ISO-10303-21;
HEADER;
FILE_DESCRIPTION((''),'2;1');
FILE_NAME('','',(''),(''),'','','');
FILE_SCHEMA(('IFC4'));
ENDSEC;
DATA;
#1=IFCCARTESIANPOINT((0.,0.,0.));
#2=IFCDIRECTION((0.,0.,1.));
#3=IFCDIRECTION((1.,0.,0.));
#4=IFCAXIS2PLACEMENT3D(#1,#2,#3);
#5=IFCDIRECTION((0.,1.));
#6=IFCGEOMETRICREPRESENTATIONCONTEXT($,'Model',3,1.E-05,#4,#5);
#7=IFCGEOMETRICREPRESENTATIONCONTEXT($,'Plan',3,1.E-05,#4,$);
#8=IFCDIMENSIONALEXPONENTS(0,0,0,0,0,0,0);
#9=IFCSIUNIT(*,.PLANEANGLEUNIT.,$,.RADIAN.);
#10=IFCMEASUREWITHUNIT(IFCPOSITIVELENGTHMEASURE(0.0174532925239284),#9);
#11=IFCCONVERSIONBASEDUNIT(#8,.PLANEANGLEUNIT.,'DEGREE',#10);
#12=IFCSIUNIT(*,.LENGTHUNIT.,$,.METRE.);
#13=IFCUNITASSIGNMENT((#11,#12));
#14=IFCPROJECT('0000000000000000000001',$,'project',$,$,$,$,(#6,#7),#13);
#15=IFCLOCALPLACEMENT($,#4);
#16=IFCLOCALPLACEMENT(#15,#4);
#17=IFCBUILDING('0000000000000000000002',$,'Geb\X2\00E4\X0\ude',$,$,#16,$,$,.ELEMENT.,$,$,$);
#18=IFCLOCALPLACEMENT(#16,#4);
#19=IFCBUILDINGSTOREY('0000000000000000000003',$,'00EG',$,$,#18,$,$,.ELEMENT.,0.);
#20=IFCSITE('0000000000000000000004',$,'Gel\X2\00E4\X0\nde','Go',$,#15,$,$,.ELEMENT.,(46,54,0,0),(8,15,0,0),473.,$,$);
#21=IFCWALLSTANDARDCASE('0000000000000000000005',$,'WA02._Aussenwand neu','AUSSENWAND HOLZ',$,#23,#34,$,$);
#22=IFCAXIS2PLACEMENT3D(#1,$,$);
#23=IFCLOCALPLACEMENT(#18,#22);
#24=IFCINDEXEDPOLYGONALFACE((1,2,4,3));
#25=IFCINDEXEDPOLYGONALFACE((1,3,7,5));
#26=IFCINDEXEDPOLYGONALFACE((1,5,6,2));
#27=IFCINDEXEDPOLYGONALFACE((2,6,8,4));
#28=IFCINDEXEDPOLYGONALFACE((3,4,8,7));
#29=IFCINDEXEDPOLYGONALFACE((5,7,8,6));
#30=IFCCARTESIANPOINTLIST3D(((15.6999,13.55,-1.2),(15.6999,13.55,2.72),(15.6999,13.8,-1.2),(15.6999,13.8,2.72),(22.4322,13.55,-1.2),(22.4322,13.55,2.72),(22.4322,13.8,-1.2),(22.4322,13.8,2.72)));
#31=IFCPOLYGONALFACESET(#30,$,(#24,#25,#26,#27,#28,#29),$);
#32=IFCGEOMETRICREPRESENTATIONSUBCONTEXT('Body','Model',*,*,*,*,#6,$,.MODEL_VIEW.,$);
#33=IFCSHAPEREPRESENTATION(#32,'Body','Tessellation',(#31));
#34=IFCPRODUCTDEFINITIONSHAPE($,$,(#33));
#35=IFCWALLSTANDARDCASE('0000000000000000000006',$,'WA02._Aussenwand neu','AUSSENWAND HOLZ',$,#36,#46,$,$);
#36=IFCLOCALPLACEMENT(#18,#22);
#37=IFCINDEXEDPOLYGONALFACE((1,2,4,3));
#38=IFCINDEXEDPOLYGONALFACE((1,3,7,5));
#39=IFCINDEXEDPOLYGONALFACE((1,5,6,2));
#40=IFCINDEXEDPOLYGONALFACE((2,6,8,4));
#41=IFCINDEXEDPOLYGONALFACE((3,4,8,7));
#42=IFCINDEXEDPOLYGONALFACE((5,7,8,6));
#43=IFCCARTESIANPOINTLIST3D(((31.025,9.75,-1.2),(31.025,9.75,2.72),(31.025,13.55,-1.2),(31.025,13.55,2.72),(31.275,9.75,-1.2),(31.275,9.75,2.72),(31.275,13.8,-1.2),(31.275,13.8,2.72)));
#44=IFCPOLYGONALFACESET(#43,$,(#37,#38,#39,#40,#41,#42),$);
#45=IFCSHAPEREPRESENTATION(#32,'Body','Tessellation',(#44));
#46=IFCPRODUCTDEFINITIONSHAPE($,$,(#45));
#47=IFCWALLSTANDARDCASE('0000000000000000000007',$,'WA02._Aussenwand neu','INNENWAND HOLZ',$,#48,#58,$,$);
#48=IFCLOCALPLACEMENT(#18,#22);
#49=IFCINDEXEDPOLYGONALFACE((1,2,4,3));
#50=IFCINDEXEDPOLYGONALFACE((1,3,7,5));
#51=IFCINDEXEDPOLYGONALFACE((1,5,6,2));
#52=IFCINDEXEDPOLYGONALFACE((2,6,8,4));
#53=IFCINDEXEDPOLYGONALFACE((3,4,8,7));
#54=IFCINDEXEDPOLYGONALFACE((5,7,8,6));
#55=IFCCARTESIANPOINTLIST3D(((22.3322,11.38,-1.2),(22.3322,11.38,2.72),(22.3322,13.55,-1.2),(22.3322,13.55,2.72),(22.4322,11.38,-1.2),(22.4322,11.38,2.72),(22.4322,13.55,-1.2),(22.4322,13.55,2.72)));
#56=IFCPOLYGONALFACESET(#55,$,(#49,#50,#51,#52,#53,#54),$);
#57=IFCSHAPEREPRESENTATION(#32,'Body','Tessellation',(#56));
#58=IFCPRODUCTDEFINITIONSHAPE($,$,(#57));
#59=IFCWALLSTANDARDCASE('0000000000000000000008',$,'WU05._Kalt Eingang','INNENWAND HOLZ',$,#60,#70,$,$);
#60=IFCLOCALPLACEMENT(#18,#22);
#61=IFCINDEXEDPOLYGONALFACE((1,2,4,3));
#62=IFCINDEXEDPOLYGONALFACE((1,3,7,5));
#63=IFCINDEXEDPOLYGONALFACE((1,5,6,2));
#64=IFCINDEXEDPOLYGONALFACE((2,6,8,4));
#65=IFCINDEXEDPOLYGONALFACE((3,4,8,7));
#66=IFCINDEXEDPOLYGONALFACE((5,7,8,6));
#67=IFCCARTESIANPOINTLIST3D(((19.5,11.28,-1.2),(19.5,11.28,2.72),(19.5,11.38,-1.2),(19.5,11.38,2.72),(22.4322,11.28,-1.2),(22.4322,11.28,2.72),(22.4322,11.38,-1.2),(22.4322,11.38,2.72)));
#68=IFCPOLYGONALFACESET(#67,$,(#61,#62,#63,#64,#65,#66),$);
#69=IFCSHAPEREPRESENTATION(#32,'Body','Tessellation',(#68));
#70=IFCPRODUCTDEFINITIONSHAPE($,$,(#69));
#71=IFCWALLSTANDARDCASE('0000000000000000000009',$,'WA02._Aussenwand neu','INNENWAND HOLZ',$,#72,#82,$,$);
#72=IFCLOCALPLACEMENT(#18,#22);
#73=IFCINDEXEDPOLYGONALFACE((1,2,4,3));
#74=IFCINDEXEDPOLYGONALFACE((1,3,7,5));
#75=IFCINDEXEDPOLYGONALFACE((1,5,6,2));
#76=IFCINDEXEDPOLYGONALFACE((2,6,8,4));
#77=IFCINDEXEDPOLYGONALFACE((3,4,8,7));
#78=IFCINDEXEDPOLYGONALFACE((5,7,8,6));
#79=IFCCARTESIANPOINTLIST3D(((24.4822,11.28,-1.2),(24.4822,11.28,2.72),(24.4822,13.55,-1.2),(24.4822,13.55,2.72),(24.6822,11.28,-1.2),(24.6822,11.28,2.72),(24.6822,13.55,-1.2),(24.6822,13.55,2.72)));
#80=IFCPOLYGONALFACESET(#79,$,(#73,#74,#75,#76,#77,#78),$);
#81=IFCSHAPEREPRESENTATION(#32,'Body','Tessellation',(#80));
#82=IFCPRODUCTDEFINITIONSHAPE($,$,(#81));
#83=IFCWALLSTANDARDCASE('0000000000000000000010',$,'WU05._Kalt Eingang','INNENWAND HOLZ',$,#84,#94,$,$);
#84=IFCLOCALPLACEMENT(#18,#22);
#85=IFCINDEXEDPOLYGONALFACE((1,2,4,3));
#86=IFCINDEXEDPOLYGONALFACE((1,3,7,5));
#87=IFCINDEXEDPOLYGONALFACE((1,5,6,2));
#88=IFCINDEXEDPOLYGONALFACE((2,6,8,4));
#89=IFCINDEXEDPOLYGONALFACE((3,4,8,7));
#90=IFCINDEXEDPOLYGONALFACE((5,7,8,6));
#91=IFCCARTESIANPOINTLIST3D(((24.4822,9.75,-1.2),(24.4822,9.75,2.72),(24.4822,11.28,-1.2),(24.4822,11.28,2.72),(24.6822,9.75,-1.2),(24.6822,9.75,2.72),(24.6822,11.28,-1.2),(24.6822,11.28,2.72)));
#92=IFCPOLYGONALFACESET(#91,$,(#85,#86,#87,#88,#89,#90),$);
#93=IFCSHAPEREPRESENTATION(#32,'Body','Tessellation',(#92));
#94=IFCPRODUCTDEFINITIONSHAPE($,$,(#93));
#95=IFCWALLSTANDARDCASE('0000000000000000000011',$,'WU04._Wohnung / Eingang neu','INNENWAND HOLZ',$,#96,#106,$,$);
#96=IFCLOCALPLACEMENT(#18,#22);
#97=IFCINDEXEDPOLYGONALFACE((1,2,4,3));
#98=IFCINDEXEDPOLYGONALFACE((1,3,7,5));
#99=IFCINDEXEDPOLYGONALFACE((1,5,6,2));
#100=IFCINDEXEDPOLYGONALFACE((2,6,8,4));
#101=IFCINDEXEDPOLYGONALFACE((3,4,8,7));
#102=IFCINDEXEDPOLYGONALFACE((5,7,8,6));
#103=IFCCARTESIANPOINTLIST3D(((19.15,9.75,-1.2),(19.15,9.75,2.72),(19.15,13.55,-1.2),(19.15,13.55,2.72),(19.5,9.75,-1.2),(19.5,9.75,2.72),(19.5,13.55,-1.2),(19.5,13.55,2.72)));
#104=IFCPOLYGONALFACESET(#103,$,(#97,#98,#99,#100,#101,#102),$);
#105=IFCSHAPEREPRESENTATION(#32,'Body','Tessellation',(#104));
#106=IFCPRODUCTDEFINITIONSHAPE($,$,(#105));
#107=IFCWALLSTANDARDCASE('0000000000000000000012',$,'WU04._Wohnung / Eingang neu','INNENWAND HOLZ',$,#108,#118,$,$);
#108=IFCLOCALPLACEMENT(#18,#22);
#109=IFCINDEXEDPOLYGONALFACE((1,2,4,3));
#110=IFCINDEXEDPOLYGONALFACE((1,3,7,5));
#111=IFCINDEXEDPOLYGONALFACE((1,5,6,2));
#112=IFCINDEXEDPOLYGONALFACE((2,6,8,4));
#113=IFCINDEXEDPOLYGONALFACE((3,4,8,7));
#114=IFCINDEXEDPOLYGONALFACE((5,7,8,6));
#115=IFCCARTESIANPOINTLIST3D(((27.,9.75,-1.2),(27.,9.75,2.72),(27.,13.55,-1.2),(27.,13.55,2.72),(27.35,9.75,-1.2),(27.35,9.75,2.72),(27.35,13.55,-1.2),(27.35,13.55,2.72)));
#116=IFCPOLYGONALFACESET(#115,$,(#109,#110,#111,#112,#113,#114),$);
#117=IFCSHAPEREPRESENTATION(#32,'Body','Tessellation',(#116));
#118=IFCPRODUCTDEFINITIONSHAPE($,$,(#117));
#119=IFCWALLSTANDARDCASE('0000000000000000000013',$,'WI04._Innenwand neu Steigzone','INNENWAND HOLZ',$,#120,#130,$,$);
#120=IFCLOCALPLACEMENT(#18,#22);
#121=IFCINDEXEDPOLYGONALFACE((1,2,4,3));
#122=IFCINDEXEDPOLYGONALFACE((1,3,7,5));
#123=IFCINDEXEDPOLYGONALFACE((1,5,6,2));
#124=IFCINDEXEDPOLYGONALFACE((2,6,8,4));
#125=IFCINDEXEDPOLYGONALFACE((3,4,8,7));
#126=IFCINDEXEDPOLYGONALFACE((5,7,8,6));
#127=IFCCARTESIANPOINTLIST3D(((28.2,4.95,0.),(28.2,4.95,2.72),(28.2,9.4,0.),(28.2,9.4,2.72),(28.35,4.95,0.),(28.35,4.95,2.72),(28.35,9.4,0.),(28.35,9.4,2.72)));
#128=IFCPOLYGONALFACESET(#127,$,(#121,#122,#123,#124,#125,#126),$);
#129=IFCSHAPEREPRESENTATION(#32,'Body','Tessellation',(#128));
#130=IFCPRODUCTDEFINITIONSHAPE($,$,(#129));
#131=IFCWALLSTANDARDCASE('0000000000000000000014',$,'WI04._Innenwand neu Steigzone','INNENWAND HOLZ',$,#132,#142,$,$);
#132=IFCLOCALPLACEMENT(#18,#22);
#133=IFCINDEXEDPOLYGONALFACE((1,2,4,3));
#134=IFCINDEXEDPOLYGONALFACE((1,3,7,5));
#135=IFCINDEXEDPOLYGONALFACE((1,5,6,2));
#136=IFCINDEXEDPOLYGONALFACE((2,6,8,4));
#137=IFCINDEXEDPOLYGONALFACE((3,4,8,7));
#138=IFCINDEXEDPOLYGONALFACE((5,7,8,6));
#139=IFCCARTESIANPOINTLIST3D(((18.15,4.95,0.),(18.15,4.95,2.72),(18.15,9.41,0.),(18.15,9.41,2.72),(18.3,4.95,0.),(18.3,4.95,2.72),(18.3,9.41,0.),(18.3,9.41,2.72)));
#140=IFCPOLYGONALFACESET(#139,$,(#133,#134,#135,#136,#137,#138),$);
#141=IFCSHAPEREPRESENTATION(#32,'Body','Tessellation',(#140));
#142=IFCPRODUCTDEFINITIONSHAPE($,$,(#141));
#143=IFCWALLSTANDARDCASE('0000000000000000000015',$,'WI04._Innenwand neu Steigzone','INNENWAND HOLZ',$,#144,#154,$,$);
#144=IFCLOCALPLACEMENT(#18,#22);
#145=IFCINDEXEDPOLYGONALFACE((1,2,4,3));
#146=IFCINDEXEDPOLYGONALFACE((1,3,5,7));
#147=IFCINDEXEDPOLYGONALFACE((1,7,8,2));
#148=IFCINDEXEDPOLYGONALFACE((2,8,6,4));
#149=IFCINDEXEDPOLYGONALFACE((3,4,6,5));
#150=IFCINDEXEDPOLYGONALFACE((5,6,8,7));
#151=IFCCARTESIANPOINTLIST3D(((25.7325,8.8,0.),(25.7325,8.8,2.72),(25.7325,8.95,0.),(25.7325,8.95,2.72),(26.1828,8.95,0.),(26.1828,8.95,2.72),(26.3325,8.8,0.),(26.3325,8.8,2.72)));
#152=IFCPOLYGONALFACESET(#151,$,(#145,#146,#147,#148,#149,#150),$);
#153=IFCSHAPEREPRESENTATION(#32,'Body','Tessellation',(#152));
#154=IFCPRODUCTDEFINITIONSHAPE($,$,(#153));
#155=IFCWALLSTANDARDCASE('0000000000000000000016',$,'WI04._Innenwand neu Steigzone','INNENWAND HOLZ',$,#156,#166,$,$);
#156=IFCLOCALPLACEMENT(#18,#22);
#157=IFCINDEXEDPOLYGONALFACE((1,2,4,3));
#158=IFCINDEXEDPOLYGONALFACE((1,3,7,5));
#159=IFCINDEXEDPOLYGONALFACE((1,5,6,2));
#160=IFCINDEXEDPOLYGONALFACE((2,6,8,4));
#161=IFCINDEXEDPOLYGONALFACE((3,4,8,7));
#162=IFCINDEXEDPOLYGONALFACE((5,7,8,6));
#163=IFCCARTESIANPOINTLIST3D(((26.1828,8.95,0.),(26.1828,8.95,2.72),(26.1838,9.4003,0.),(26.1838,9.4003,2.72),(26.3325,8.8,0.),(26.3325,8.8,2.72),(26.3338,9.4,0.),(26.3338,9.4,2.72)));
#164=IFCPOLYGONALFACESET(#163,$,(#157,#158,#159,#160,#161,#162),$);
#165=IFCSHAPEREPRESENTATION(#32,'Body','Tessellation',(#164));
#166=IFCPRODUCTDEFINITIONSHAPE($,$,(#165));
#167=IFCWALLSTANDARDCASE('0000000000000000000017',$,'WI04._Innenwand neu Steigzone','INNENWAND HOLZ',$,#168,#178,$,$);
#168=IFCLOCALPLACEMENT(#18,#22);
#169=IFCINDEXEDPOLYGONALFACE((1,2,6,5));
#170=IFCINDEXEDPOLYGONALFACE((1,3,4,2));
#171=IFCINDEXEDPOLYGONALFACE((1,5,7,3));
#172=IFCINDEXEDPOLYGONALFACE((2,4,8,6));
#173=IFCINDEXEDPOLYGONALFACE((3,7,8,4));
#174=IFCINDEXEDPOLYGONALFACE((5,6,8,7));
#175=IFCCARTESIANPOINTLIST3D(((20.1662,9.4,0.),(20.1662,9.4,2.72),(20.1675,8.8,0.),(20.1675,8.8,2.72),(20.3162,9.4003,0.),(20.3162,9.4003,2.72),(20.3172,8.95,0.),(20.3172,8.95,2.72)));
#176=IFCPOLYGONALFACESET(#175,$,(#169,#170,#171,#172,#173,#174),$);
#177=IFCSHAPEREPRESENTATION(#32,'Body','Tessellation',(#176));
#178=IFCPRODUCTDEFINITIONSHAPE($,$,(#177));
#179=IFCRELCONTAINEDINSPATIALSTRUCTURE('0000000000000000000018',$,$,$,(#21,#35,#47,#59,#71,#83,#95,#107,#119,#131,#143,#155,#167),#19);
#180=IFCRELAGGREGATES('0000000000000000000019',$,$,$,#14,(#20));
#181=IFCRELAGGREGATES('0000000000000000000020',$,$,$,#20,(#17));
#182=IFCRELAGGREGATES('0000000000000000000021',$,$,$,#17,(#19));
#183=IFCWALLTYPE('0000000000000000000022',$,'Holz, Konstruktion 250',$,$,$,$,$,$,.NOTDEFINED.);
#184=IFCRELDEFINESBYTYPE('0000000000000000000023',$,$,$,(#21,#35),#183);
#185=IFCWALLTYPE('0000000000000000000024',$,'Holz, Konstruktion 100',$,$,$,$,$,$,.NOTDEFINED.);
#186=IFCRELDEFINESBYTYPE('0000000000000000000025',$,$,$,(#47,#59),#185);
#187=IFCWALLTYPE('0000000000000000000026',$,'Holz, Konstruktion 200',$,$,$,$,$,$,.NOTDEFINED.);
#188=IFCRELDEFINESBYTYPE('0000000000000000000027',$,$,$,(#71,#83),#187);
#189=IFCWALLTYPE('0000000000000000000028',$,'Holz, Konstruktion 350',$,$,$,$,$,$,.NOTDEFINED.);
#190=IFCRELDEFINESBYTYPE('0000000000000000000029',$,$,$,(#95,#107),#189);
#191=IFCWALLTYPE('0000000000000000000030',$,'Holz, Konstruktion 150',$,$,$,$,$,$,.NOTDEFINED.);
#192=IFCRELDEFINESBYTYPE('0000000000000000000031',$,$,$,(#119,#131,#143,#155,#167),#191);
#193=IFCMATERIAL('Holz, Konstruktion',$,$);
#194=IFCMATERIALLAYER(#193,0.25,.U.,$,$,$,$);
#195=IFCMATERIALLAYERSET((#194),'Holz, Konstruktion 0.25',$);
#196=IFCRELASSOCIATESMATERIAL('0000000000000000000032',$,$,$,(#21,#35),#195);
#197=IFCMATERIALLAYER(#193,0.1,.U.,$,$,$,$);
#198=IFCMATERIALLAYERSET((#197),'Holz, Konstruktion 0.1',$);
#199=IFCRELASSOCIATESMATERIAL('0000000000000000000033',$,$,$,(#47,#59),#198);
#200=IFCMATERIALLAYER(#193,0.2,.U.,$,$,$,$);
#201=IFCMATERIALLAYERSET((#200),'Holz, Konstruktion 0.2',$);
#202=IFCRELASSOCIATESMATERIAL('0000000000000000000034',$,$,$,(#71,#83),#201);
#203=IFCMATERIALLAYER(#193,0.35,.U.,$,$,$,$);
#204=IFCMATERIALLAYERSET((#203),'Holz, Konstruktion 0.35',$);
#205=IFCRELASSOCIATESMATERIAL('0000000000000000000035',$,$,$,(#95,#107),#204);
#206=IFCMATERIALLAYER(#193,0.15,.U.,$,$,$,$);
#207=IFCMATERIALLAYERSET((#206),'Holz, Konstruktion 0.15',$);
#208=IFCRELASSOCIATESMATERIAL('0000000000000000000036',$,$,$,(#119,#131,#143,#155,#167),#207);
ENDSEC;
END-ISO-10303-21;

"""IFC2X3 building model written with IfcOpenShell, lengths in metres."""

from ifc_helpers import new_model, entity, si_unit, converted_unit, direction, frame, origin_with_axes, place, context, subcontext, project, spatial, polyline, outline, extrude, material, layer, layer_set, layer_usage, type_object, element, save


model = new_model("IFC2X3")

# Units and contexts
model_context = context("Model", 3, precision=1e-05, world=origin_with_axes(), true_north=direction((0.0, 1.0)))
plan_context = context("Plan", 3, precision=1e-05, world=origin_with_axes())
body_context = subcontext(model_context, "Body", "Model", "MODEL_VIEW")
ifc_project = project(units=[converted_unit("PLANEANGLEUNIT", "DEGREE", entity("IfcPositiveLengthMeasure", 0.0174532925239284), si_unit("PLANEANGLEUNIT", "RADIAN"), dimensions=[0, 0, 0, 0, 0, 0, 0]), si_unit("LENGTHUNIT", "METRE")], contexts=[model_context, plan_context])

# Site, building, storey
site_placement = place(None, origin_with_axes())
site = spatial("IfcSite", under=ifc_project, at=site_placement, Name="Gelände", Description="Go", CompositionType="ELEMENT", RefLatitude=(46, 54, 0, 0), RefLongitude=(8, 15, 0, 0), RefElevation=473.0)
building_placement = place(site_placement, origin_with_axes())
building = spatial("IfcBuilding", under=site, at=building_placement, Name="Gebäude", CompositionType="ELEMENT")
storey_placement = place(building_placement, origin_with_axes())
storey = spatial("IfcBuildingStorey", under=building, at=storey_placement, Name="00EG", CompositionType="ELEMENT", Elevation=0.0)

# Shared definitions
ifc_material_1 = material(Name="Holz, Konstruktion")

# Walls
ifc_layer_1 = layer(ifc_material_1, 0.25, ventilated="UNKNOWN")
ifc_layer_set_1 = layer_set([ifc_layer_1], Name="Holz, Konstruktion 0.25")
wall_type_1 = type_object("IfcWallType", Name="Holz, Konstruktion 250", PredefinedType="NOTDEFINED")
ifc_layer_usage_1 = layer_usage(ifc_layer_set_1, "AXIS2", "POSITIVE", 0.0)
wall_1_placement = place(storey_placement, frame((22.4322, 13.8, -1.2), z_axis=(0.0, 0.0, 1.0), x_axis=(-1.0, 0.0, 0.0)))
element("IfcWallStandardCase", 1, at=wall_1_placement, inside=storey, type_object=wall_type_1, material=ifc_layer_usage_1, Name="WA02._Aussenwand neu", Description="AUSSENWAND HOLZ", context=body_context, shape_type="SweptSolid", body=[
    extrude(outline(polyline([(0.0, 0.0), (6.7323, 0.0), (6.7323, 0.25), (0.0, 0.25), (0.0, 0.0)])), origin_with_axes(), (0.0, 0.0, 1.0), 3.92),
])
ifc_layer_usage_2 = layer_usage(ifc_layer_set_1, "AXIS2", "POSITIVE", 0.0)
wall_2_placement = place(storey_placement, frame((31.275, 9.75, -1.2), z_axis=(0.0, 0.0, 1.0), x_axis=(0.0, 1.0, 0.0)))
element("IfcWallStandardCase", 2, at=wall_2_placement, inside=storey, type_object=wall_type_1, material=ifc_layer_usage_2, Name="WA02._Aussenwand neu", Description="AUSSENWAND HOLZ", context=body_context, shape_type="SweptSolid", body=[
    extrude(outline(polyline([(0.0, 0.0), (4.05, 0.0), (3.8, 0.25), (0.0, 0.25), (0.0, 0.0)])), origin_with_axes(), (0.0, 0.0, 1.0), 3.92),
])
ifc_layer_2 = layer(ifc_material_1, 0.1, ventilated="UNKNOWN")
ifc_layer_set_2 = layer_set([ifc_layer_2], Name="Holz, Konstruktion 0.1")
wall_type_2 = type_object("IfcWallType", Name="Holz, Konstruktion 100", PredefinedType="NOTDEFINED")
ifc_layer_usage_3 = layer_usage(ifc_layer_set_2, "AXIS2", "NEGATIVE", 0.0)
wall_3_placement = place(storey_placement, frame((22.4322, 13.55, -1.2), z_axis=(0.0, 0.0, 1.0), x_axis=(0.0, -1.0, 0.0)))
element("IfcWallStandardCase", 3, at=wall_3_placement, inside=storey, type_object=wall_type_2, material=ifc_layer_usage_3, Name="WA02._Aussenwand neu", Description="INNENWAND HOLZ", context=body_context, shape_type="SweptSolid", body=[
    extrude(outline(polyline([(0.0, -0.1), (2.17, -0.1), (2.17, 0.0), (0.0, 0.0), (0.0, -0.1)])), origin_with_axes(), (0.0, 0.0, 1.0), 3.92),
])
ifc_layer_usage_4 = layer_usage(ifc_layer_set_2, "AXIS2", "NEGATIVE", 0.0)
wall_4_placement = place(storey_placement, frame((22.4322, 11.28, -1.2), z_axis=(0.0, 0.0, 1.0), x_axis=(-1.0, 0.0, 0.0)))
element("IfcWallStandardCase", 4, at=wall_4_placement, inside=storey, type_object=wall_type_2, material=ifc_layer_usage_4, Name="WU05._Kalt Eingang", Description="INNENWAND HOLZ", context=body_context, shape_type="SweptSolid", body=[
    extrude(outline(polyline([(0.0, -0.1), (2.9322, -0.1), (2.9322, 0.0), (0.0, 0.0), (0.0, -0.1)])), origin_with_axes(), (0.0, 0.0, 1.0), 3.92),
])
ifc_layer_3 = layer(ifc_material_1, 0.2, ventilated="UNKNOWN")
ifc_layer_set_3 = layer_set([ifc_layer_3], Name="Holz, Konstruktion 0.2")
ifc_layer_usage_5 = layer_usage(ifc_layer_set_3, "AXIS2", "NEGATIVE", 0.0)
wall_type_3 = type_object("IfcWallType", Name="Holz, Konstruktion 200", PredefinedType="NOTDEFINED")
wall_5_placement = place(storey_placement, frame((24.6822, 13.55, -1.2), z_axis=(0.0, 0.0, 1.0), x_axis=(0.0, -1.0, 0.0)))
element("IfcWallStandardCase", 5, at=wall_5_placement, inside=storey, type_object=wall_type_3, material=ifc_layer_usage_5, Name="WA02._Aussenwand neu", Description="INNENWAND HOLZ", context=body_context, shape_type="SweptSolid", body=[
    extrude(outline(polyline([(0.0, -0.2), (2.27, -0.2), (2.27, 0.0), (0.0, 0.0), (0.0, -0.2)])), origin_with_axes(), (0.0, 0.0, 1.0), 3.92),
])
ifc_layer_usage_6 = layer_usage(ifc_layer_set_3, "AXIS2", "NEGATIVE", 0.0)
wall_6_placement = place(storey_placement, frame((24.6822, 11.28, -1.2), z_axis=(0.0, 0.0, 1.0), x_axis=(0.0, -1.0, 0.0)))
element("IfcWallStandardCase", 6, at=wall_6_placement, inside=storey, type_object=wall_type_3, material=ifc_layer_usage_6, Name="WU05._Kalt Eingang", Description="INNENWAND HOLZ", context=body_context, shape_type="SweptSolid", body=[
    extrude(outline(polyline([(0.0, -0.2), (1.53, -0.2), (1.53, 0.0), (0.0, 0.0), (0.0, -0.2)])), origin_with_axes(), (0.0, 0.0, 1.0), 3.92),
])
ifc_layer_4 = layer(ifc_material_1, 0.35, ventilated="UNKNOWN")
ifc_layer_set_4 = layer_set([ifc_layer_4], Name="Holz, Konstruktion 0.35")
ifc_layer_usage_7 = layer_usage(ifc_layer_set_4, "AXIS2", "POSITIVE", 0.0)
wall_type_4 = type_object("IfcWallType", Name="Holz, Konstruktion 350", PredefinedType="NOTDEFINED")
wall_7_placement = place(storey_placement, frame((19.15, 13.55, -1.2), z_axis=(0.0, 0.0, 1.0), x_axis=(0.0, -1.0, 0.0)))
element("IfcWallStandardCase", 7, at=wall_7_placement, inside=storey, type_object=wall_type_4, material=ifc_layer_usage_7, Name="WU04._Wohnung / Eingang neu", Description="INNENWAND HOLZ", context=body_context, shape_type="SweptSolid", body=[
    extrude(outline(polyline([(0.0, 0.0), (3.8, 0.0), (3.8, 0.35), (0.0, 0.35), (0.0, 0.0)])), origin_with_axes(), (0.0, 0.0, 1.0), 3.92),
])
ifc_layer_usage_8 = layer_usage(ifc_layer_set_4, "AXIS2", "POSITIVE", 0.0)
wall_8_placement = place(storey_placement, frame((27.0, 13.55, -1.2), z_axis=(0.0, 0.0, 1.0), x_axis=(0.0, -1.0, 0.0)))
element("IfcWallStandardCase", 8, at=wall_8_placement, inside=storey, type_object=wall_type_4, material=ifc_layer_usage_8, Name="WU04._Wohnung / Eingang neu", Description="INNENWAND HOLZ", context=body_context, shape_type="SweptSolid", body=[
    extrude(outline(polyline([(0.0, 0.0), (3.8, 0.0), (3.8, 0.35), (0.0, 0.35), (0.0, 0.0)])), origin_with_axes(), (0.0, 0.0, 1.0), 3.92),
])
ifc_layer_5 = layer(ifc_material_1, 0.15, ventilated="UNKNOWN")
ifc_layer_set_5 = layer_set([ifc_layer_5], Name="Holz, Konstruktion 0.15")
ifc_layer_usage_9 = layer_usage(ifc_layer_set_5, "AXIS2", "POSITIVE", 0.0)
wall_type_5 = type_object("IfcWallType", Name="Holz, Konstruktion 150", PredefinedType="NOTDEFINED")
wall_9_placement = place(storey_placement, frame((28.2, 9.4, 0.0), z_axis=(0.0, 0.0, 1.0), x_axis=(0.0, -1.0, 0.0)))
element("IfcWallStandardCase", 9, at=wall_9_placement, inside=storey, type_object=wall_type_5, material=ifc_layer_usage_9, Name="WI04._Innenwand neu Steigzone", Description="INNENWAND HOLZ", context=body_context, shape_type="SweptSolid", body=[
    extrude(outline(polyline([(0.0, 0.0), (4.45, 0.0), (4.45, 0.15), (0.0, 0.15), (0.0, 0.0)])), origin_with_axes(), (0.0, 0.0, 1.0), 2.72),
])
ifc_layer_usage_10 = layer_usage(ifc_layer_set_5, "AXIS2", "NEGATIVE", 0.0)
wall_10_placement = place(storey_placement, frame((18.3, 9.41, 0.0), z_axis=(0.0, 0.0, 1.0), x_axis=(0.0, -1.0, 0.0)))
element("IfcWallStandardCase", 10, at=wall_10_placement, inside=storey, type_object=wall_type_5, material=ifc_layer_usage_10, Name="WI04._Innenwand neu Steigzone", Description="INNENWAND HOLZ", context=body_context, shape_type="SweptSolid", body=[
    extrude(outline(polyline([(0.0, -0.15), (4.46, -0.15), (4.46, 0.0), (0.0, 0.0), (0.0, -0.15)])), origin_with_axes(), (0.0, 0.0, 1.0), 2.72),
])
ifc_layer_usage_11 = layer_usage(ifc_layer_set_5, "AXIS2", "NEGATIVE", 0.0)
wall_11_placement = place(storey_placement, frame((26.3325, 8.8, 0.0), z_axis=(0.0, 0.0, 1.0), x_axis=(-1.0, 0.0, 0.0)))
element("IfcWallStandardCase", 11, at=wall_11_placement, inside=storey, type_object=wall_type_5, material=ifc_layer_usage_11, Name="WI04._Innenwand neu Steigzone", Description="INNENWAND HOLZ", context=body_context, shape_type="SweptSolid", body=[
    extrude(outline(polyline([(0.1497, -0.15), (0.6, -0.15), (0.6, 0.0), (0.0, 0.0), (0.1497, -0.15)])), origin_with_axes(), (0.0, 0.0, 1.0), 2.72),
])
ifc_layer_usage_12 = layer_usage(ifc_layer_set_5, "AXIS2", "NEGATIVE", 0.0)
wall_12_placement = place(storey_placement, frame((26.3338, 9.4, 0.0), z_axis=(0.0, 0.0, 1.0), x_axis=(-0.002118, -0.999998, 0.0)))
element("IfcWallStandardCase", 12, at=wall_12_placement, inside=storey, type_object=wall_type_5, material=ifc_layer_usage_12, Name="WI04._Innenwand neu Steigzone", Description="INNENWAND HOLZ", context=body_context, shape_type="SweptSolid", body=[
    extrude(outline(polyline([(0.0, -0.15), (0.4503, -0.15), (0.6, 0.0), (0.0, 0.0), (0.0, -0.15)])), origin_with_axes(), (0.0, 0.0, 1.0), 2.72),
])
ifc_layer_usage_13 = layer_usage(ifc_layer_set_5, "AXIS2", "POSITIVE", 0.0)
wall_13_placement = place(storey_placement, frame((20.1662, 9.4, 0.0), z_axis=(0.0, 0.0, 1.0), x_axis=(0.002118, -0.999998, 0.0)))
element("IfcWallStandardCase", 13, at=wall_13_placement, inside=storey, type_object=wall_type_5, material=ifc_layer_usage_13, Name="WI04._Innenwand neu Steigzone", Description="INNENWAND HOLZ", context=body_context, shape_type="SweptSolid", body=[
    extrude(outline(polyline([(0.0, 0.0), (0.6, 0.0), (0.4503, 0.15), (0.0, 0.15), (0.0, 0.0)])), origin_with_axes(), (0.0, 0.0, 1.0), 2.72),
])

save(model, "model.ifc")
